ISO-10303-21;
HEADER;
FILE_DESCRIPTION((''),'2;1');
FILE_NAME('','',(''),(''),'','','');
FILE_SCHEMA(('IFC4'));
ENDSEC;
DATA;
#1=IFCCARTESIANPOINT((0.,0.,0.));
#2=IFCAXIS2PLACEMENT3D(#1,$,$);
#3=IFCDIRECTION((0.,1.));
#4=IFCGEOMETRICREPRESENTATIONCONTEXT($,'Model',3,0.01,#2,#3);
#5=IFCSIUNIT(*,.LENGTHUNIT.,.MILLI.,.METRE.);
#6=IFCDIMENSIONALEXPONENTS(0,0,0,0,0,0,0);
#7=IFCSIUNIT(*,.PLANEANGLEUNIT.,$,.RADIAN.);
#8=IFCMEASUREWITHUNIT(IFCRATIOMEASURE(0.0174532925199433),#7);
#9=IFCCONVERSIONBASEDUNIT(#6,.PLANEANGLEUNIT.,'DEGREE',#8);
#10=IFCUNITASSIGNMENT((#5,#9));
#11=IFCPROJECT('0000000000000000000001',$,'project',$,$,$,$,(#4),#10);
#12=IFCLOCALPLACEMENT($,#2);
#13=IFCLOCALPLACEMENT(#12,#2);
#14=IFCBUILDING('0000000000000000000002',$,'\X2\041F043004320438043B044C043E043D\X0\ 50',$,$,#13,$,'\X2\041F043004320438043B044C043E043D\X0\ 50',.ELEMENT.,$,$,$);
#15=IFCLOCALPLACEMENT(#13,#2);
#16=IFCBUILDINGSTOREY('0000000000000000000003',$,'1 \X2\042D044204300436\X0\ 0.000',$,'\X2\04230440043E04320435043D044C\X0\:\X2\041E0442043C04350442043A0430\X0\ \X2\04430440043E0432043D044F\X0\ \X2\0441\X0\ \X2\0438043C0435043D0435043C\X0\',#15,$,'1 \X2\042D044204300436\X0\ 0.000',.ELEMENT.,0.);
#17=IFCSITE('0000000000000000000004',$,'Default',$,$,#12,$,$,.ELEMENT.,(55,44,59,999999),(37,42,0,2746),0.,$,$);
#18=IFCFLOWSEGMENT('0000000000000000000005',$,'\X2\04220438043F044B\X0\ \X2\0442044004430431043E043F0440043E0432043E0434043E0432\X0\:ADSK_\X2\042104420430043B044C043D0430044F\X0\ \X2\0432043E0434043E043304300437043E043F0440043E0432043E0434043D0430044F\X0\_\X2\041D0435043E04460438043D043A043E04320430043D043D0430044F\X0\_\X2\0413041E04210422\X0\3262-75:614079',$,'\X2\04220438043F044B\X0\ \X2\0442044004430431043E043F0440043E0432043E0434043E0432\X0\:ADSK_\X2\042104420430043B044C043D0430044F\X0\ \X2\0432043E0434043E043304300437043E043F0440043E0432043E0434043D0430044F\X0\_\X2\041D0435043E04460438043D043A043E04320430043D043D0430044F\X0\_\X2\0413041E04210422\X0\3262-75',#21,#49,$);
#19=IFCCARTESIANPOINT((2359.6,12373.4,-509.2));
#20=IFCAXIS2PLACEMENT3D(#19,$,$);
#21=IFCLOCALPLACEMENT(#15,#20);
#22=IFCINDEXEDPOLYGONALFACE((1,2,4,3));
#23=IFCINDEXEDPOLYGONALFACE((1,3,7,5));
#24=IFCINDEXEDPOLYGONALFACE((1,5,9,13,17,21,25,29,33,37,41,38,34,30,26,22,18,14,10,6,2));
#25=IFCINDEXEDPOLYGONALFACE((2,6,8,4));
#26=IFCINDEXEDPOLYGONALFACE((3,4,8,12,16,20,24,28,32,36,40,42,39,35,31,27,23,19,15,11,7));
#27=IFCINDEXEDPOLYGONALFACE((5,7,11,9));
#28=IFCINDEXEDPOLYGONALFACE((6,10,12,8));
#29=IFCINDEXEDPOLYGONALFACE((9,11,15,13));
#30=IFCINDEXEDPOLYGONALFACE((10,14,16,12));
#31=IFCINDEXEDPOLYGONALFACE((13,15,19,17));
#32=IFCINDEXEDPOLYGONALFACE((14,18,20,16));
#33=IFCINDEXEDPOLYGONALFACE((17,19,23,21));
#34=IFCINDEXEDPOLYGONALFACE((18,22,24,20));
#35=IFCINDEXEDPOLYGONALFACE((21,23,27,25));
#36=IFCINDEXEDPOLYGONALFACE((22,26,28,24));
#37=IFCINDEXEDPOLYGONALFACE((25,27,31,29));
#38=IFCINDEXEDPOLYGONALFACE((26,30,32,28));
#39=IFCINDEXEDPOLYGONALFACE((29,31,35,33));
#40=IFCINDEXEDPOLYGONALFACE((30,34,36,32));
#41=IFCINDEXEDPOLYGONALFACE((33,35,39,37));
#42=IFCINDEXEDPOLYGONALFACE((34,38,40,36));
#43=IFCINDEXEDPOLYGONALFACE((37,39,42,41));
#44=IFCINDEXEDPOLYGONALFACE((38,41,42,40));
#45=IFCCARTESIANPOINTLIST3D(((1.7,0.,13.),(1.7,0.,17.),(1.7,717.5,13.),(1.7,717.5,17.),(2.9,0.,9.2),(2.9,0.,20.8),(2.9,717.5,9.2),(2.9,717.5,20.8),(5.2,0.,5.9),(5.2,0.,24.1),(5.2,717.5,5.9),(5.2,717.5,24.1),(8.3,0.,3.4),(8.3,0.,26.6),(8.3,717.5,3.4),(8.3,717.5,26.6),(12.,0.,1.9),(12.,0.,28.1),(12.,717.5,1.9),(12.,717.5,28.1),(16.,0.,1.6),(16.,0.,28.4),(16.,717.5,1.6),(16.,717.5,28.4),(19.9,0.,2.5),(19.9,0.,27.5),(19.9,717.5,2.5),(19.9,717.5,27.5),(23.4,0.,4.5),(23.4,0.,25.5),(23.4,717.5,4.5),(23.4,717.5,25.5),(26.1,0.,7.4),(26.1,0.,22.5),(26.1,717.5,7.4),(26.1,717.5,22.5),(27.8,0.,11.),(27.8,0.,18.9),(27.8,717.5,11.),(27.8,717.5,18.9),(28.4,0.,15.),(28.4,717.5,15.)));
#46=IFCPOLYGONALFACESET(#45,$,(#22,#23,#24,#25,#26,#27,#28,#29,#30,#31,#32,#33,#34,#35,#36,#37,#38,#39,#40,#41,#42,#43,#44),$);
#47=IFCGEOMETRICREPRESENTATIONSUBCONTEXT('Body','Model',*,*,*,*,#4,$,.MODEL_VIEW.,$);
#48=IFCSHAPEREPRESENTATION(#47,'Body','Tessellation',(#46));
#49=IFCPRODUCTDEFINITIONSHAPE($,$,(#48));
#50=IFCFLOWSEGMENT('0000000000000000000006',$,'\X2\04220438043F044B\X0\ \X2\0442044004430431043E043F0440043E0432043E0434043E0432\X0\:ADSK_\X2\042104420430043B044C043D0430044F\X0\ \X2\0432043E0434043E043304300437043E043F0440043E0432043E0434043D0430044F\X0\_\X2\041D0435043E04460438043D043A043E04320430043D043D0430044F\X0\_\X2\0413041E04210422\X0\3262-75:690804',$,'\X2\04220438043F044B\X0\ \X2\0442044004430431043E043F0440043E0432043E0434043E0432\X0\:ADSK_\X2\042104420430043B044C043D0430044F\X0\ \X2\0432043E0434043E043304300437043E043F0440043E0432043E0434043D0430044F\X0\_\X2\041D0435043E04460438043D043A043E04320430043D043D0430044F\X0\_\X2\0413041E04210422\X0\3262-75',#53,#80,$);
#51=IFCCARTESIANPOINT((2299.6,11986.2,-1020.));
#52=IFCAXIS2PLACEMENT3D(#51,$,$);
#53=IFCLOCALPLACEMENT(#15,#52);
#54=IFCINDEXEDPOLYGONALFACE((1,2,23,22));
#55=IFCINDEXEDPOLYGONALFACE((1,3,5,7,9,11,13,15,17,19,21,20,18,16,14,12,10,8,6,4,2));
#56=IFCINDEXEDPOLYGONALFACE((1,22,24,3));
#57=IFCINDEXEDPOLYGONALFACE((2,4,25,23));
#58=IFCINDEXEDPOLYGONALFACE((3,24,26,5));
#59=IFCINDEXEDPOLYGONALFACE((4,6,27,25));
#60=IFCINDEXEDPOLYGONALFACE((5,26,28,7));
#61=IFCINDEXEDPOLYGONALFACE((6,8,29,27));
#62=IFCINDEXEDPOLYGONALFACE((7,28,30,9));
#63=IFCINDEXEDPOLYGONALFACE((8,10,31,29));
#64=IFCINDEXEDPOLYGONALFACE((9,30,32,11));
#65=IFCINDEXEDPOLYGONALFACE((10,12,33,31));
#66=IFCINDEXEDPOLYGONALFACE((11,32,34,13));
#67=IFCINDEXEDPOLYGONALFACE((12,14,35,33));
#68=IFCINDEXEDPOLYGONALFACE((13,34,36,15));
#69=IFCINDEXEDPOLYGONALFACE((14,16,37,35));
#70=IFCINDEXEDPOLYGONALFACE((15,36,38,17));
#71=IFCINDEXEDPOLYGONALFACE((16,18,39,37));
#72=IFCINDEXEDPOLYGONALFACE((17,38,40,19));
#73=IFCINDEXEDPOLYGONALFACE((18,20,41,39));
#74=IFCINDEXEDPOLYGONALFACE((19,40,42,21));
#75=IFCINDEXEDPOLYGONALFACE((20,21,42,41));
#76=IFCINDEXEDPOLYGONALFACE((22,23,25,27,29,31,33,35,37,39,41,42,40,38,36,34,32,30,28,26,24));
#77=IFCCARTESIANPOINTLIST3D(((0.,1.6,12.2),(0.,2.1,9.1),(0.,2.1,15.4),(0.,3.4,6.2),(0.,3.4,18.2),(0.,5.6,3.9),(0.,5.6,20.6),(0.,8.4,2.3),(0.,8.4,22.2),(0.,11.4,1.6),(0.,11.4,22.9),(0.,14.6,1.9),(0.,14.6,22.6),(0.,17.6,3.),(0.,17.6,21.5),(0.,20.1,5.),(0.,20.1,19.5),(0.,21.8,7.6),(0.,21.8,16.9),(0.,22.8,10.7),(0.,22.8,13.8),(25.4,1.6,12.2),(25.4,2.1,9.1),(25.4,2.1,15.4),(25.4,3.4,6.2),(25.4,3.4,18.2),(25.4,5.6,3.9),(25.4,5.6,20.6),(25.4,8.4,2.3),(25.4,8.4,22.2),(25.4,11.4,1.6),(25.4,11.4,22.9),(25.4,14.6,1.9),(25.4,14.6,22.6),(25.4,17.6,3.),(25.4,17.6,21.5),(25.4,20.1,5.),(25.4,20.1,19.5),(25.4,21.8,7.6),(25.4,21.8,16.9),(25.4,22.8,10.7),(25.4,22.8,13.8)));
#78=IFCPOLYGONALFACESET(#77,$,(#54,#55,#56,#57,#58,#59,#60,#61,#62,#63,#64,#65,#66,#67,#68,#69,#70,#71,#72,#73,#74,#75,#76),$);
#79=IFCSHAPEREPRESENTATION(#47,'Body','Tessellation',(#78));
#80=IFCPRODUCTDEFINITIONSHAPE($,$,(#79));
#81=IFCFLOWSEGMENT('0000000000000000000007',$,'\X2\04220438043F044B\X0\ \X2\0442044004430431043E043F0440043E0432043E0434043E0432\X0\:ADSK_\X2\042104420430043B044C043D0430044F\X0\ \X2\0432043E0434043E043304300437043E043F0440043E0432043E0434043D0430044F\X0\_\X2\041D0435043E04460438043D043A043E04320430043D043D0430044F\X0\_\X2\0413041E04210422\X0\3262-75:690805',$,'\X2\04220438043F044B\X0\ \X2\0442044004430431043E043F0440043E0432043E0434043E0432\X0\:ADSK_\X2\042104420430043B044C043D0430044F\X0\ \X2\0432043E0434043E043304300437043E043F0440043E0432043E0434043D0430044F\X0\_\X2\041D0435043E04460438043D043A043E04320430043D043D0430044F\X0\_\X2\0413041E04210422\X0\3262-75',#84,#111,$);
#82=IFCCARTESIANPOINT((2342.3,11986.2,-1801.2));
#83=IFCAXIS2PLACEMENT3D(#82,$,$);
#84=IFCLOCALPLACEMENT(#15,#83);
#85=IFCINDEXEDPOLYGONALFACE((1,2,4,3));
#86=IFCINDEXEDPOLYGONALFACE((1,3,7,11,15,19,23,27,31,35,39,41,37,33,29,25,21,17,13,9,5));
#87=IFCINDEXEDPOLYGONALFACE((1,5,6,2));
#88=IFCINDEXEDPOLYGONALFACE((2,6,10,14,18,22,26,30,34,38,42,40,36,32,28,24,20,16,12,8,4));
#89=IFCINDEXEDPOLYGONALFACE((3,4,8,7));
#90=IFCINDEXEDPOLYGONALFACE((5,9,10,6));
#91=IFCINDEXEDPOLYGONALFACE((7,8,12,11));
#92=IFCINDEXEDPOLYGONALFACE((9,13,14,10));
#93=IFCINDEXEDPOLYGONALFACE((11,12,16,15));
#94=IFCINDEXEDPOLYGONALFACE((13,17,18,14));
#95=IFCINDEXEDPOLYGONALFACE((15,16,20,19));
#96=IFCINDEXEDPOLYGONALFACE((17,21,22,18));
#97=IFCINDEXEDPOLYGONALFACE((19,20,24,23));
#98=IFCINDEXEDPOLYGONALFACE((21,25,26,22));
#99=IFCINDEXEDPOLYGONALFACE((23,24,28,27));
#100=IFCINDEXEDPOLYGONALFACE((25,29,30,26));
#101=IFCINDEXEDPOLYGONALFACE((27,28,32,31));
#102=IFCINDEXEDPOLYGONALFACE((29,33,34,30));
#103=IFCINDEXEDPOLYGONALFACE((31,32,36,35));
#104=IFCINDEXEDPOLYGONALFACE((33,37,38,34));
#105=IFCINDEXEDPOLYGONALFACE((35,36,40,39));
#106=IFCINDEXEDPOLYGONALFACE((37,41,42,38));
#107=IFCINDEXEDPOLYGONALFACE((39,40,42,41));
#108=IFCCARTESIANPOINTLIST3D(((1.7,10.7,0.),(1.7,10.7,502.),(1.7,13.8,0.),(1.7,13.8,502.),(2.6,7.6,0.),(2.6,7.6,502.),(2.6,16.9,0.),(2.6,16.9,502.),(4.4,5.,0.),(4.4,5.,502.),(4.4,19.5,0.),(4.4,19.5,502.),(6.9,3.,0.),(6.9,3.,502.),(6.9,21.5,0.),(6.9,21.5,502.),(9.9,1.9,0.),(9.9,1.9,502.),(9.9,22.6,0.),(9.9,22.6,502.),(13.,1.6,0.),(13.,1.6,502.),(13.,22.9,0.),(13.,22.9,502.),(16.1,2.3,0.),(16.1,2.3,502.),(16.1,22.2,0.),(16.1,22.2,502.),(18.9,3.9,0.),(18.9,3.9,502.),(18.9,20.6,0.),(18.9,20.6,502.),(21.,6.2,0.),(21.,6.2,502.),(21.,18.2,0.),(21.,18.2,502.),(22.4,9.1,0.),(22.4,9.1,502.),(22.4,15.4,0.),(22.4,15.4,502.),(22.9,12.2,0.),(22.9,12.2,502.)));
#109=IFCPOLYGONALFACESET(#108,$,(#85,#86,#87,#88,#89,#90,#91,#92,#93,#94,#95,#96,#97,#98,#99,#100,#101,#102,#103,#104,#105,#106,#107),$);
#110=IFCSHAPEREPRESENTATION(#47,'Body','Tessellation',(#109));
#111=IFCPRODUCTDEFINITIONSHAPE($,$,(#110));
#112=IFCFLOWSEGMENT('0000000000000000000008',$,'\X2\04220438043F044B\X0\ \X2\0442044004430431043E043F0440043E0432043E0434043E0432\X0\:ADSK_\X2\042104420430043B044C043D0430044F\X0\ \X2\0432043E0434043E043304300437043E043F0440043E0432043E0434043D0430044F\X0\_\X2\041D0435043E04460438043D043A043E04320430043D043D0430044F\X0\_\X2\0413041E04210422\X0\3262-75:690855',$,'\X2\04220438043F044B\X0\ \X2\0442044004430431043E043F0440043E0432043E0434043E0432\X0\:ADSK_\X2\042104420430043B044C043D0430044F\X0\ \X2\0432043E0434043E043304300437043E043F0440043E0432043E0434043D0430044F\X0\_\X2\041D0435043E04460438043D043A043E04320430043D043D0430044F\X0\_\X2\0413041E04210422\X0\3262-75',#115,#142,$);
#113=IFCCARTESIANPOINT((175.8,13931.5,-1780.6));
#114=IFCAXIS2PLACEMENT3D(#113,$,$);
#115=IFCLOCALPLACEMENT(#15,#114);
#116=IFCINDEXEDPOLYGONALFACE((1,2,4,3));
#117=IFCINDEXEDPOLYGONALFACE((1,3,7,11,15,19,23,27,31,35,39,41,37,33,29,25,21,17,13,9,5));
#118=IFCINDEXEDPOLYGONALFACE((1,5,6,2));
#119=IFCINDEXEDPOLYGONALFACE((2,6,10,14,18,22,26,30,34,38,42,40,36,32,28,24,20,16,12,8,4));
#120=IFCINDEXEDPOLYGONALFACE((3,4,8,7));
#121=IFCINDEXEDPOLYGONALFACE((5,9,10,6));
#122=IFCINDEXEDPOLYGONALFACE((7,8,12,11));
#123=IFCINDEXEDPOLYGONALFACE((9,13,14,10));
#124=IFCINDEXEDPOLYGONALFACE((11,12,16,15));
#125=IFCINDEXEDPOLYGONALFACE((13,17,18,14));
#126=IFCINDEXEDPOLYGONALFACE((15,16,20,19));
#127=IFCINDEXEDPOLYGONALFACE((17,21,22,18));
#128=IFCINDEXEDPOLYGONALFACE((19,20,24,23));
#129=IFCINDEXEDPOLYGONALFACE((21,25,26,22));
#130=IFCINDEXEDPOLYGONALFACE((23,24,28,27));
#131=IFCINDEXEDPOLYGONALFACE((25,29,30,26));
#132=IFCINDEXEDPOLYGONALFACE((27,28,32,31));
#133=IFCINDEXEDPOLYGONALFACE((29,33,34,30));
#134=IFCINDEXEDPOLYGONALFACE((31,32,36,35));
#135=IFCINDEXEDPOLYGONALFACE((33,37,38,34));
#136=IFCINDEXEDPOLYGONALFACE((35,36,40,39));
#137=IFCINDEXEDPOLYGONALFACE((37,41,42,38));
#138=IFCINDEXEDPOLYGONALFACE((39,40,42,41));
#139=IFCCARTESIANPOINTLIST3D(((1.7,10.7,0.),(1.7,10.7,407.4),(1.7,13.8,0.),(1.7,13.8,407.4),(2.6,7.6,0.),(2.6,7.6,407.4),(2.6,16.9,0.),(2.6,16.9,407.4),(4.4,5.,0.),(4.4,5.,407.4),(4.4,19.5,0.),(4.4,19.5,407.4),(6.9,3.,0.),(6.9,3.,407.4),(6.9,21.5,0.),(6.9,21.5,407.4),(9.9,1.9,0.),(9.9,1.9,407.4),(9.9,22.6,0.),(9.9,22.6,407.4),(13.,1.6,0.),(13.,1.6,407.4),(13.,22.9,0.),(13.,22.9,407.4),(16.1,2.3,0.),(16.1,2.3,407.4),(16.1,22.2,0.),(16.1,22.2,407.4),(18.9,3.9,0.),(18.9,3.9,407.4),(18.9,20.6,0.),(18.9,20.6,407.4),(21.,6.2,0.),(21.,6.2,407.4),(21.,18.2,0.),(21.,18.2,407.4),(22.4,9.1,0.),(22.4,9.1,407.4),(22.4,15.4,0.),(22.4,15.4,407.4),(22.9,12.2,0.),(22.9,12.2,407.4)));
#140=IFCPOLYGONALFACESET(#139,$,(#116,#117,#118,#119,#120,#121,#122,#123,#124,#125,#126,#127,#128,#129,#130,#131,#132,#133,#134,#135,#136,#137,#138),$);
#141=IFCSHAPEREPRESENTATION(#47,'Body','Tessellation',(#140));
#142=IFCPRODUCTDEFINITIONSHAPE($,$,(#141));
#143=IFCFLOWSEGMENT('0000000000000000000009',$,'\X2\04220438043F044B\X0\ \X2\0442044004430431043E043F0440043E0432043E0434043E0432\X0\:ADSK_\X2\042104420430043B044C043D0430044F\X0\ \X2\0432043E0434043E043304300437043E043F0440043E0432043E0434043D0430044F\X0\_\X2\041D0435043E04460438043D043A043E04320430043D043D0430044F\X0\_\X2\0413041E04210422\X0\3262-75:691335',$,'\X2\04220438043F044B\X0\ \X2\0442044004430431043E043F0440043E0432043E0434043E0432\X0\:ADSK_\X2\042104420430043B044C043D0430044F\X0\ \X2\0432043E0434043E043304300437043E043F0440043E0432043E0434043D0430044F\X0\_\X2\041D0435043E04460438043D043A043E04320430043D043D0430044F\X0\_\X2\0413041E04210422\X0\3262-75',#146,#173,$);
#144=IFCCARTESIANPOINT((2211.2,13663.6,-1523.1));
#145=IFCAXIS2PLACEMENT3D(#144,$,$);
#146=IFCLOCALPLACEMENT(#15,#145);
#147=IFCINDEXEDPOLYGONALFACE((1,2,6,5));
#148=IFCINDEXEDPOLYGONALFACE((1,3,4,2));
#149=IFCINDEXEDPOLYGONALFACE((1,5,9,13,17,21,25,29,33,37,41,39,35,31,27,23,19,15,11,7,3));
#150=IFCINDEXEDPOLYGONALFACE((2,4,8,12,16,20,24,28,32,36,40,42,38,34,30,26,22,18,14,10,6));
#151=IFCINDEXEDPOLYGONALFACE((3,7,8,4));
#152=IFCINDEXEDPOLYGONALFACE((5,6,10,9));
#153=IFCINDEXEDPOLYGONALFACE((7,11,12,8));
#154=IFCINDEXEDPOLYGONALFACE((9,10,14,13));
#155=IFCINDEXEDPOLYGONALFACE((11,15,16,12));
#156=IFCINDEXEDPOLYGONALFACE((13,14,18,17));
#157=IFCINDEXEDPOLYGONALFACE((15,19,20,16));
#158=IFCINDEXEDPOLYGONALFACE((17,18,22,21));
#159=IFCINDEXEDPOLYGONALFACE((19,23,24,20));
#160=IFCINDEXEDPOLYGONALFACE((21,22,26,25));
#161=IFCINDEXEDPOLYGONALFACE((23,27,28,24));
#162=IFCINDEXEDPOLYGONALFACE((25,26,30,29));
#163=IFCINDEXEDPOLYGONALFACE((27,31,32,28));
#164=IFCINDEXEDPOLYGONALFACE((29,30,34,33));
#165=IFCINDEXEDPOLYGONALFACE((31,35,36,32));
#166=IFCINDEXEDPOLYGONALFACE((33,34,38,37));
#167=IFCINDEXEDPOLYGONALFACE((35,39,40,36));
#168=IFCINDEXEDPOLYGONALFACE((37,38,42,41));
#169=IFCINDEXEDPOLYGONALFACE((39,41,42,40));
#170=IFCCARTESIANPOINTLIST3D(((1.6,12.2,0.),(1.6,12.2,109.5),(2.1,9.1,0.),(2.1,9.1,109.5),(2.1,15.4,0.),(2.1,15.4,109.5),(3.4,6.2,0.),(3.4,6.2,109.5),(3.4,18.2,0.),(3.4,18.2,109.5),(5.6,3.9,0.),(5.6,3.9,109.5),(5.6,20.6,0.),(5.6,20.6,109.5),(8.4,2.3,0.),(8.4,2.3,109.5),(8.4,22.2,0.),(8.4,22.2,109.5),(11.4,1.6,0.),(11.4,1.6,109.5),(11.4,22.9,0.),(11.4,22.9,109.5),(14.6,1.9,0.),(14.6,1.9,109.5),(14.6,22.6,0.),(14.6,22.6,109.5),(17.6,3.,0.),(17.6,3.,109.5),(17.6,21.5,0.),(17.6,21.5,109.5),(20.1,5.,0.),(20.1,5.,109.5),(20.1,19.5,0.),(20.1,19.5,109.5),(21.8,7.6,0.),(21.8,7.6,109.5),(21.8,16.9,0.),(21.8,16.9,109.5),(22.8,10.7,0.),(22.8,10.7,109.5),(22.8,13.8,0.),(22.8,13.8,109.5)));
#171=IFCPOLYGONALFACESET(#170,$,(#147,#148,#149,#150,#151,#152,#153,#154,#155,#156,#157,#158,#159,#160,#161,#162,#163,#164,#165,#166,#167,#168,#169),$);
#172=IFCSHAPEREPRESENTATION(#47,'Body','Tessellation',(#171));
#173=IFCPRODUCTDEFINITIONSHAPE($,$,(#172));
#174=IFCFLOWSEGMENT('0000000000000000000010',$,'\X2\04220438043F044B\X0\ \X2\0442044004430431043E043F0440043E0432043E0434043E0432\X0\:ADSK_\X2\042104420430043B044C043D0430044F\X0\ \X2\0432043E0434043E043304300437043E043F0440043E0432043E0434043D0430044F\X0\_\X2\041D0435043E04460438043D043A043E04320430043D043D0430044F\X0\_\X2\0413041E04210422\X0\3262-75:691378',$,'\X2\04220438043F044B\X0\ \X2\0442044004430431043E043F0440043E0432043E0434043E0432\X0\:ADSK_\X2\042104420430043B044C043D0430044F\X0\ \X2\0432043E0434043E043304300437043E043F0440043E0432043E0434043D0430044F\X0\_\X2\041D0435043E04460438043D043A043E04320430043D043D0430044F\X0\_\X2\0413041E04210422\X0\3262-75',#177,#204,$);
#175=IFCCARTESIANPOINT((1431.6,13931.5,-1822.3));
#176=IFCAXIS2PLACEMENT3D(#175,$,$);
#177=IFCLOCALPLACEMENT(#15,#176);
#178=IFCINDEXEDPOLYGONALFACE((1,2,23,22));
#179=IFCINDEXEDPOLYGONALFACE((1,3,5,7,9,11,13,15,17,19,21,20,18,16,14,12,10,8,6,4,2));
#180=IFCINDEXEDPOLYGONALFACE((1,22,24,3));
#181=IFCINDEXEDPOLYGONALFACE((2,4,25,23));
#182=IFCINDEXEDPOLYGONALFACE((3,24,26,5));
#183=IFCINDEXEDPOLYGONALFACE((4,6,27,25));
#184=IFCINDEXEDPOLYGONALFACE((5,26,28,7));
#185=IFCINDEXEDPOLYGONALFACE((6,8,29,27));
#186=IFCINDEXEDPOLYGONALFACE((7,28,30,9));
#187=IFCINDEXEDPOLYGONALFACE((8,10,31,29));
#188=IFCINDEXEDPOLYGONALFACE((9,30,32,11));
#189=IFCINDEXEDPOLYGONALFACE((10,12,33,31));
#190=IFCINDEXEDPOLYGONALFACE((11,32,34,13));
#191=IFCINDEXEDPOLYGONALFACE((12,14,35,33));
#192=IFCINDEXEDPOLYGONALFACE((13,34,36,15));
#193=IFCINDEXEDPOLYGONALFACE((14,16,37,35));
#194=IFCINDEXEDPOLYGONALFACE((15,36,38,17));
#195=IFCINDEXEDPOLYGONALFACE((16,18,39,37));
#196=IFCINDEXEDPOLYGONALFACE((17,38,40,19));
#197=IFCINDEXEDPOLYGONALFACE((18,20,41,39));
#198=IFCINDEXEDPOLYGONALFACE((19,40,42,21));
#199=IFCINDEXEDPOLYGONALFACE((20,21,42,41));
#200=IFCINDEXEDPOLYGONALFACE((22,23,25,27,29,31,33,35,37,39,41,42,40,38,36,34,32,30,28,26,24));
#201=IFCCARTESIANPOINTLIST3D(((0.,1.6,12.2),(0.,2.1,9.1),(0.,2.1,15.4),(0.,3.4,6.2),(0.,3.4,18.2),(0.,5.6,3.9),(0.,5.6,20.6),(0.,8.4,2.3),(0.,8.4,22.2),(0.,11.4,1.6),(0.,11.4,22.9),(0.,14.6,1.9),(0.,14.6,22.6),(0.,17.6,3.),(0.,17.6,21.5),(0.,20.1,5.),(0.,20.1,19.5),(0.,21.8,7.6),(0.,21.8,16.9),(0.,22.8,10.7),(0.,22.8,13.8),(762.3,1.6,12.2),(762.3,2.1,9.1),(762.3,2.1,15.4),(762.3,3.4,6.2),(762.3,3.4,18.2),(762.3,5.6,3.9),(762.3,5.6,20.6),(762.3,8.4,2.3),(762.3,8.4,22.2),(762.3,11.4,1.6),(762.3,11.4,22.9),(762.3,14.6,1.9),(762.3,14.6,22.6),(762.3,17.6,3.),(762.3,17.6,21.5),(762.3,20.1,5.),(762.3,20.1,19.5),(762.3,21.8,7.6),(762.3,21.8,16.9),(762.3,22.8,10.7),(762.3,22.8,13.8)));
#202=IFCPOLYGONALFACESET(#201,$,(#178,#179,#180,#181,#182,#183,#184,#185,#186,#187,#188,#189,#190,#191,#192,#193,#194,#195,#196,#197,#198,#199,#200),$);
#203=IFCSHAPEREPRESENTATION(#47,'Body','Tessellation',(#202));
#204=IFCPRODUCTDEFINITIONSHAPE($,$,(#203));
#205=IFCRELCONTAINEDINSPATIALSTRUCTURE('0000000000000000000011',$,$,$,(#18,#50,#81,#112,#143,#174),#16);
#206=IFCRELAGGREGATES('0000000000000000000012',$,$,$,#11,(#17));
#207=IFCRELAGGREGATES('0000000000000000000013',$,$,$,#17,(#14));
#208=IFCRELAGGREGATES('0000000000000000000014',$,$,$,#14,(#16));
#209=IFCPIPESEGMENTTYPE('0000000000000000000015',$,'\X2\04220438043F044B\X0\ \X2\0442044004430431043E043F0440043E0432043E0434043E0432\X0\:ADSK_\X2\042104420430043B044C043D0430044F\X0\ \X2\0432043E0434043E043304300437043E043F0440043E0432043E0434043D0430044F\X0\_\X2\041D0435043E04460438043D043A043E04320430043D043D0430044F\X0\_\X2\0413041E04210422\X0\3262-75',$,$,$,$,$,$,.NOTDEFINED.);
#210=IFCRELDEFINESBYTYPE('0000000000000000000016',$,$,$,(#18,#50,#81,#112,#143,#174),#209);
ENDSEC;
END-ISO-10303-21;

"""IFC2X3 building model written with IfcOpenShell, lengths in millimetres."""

from ifc_helpers import new_model, entity, si_unit, converted_unit, direction, frame, frame_2d, origin, origin_2d_with_axis, place, context, subcontext, project, spatial, circle, extrude, type_object, element, save


model = new_model("IFC2X3")

# Units and contexts
model_context = context("Model", 3, precision=0.01, world=origin(), true_north=direction((0.0, 1.0)))
body_context = subcontext(model_context, "Body", "Model", "MODEL_VIEW")
ifc_project = project(units=[si_unit("LENGTHUNIT", "METRE", prefix="MILLI"), converted_unit("PLANEANGLEUNIT", "DEGREE", entity("IfcRatioMeasure", 0.0174532925199433), si_unit("PLANEANGLEUNIT", "RADIAN"), dimensions=[0, 0, 0, 0, 0, 0, 0])], contexts=[model_context])

# Site, building, storey
site_placement = place(None, origin())
site = spatial("IfcSite", under=ifc_project, at=site_placement, Name="Default", CompositionType="ELEMENT", RefLatitude=(55, 44, 59, 999999), RefLongitude=(37, 42, 0, 2746), RefElevation=0.0)
building_placement = place(site_placement, origin())
building = spatial("IfcBuilding", under=site, at=building_placement, Name="Павильон 50", LongName="Павильон 50", CompositionType="ELEMENT")
storey_placement = place(building_placement, origin())
storey = spatial("IfcBuildingStorey", under=building, at=storey_placement, Name="1 Этаж 0.000", ObjectType="Уровень:Отметка уровня с именем", LongName="1 Этаж 0.000", CompositionType="ELEMENT", Elevation=0.0)

# Flow segments
pipe_segment_type = type_object("IfcPipeSegmentType", Name="Типы трубопроводов:ADSK_Стальная водогазопроводная_Неоцинкованная_ГОСТ3262-75", PredefinedType="NOTDEFINED")
flow_segment_1_placement = place(storey_placement, frame((2359.6, 12373.4, -509.2)))
element("IfcFlowSegment", 1, at=flow_segment_1_placement, inside=storey, type_object=pipe_segment_type, Name="Типы трубопроводов:ADSK_Стальная водогазопроводная_Неоцинкованная_ГОСТ3262-75:614079", ObjectType="Типы трубопроводов:ADSK_Стальная водогазопроводная_Неоцинкованная_ГОСТ3262-75", context=body_context, shape_type="SweptSolid", body=[
    extrude(circle(Radius=13.4, at=frame_2d((0.0, 0.0), x_axis=(1.0, 0.0))), frame((15.0, 0.0, 15.0), z_axis=(0.0, 1.0, 0.0), x_axis=(1.0, 0.0, 0.0)), (0.0, 0.0, 1.0), 717.5),
])
flow_segment_2_placement = place(storey_placement, frame((2299.6, 11986.2, -1020.0)))
element("IfcFlowSegment", 2, at=flow_segment_2_placement, inside=storey, type_object=pipe_segment_type, Name="Типы трубопроводов:ADSK_Стальная водогазопроводная_Неоцинкованная_ГОСТ3262-75:690804", ObjectType="Типы трубопроводов:ADSK_Стальная водогазопроводная_Неоцинкованная_ГОСТ3262-75", context=body_context, shape_type="SweptSolid", body=[
    extrude(circle(Radius=10.7, at=origin_2d_with_axis()), frame((0.0, 12.2, 12.2), z_axis=(1.0, 0.0, 0.0), x_axis=(0.0, -1.0, 0.0)), (0.0, 0.0, 1.0), 25.4),
])
flow_segment_3_placement = place(storey_placement, frame((2342.3, 11986.2, -1801.2)))
element("IfcFlowSegment", 3, at=flow_segment_3_placement, inside=storey, type_object=pipe_segment_type, Name="Типы трубопроводов:ADSK_Стальная водогазопроводная_Неоцинкованная_ГОСТ3262-75:690805", ObjectType="Типы трубопроводов:ADSK_Стальная водогазопроводная_Неоцинкованная_ГОСТ3262-75", context=body_context, shape_type="SweptSolid", body=[
    extrude(circle(Radius=10.7, at=frame_2d((0.0, 0.0), x_axis=(1.0, 0.0))), frame((12.2, 12.2, 0.0)), (0.0, 0.0, 1.0), 502.0),
])
flow_segment_4_placement = place(storey_placement, frame((175.8, 13931.5, -1780.6)))
element("IfcFlowSegment", 4, at=flow_segment_4_placement, inside=storey, type_object=pipe_segment_type, Name="Типы трубопроводов:ADSK_Стальная водогазопроводная_Неоцинкованная_ГОСТ3262-75:690855", ObjectType="Типы трубопроводов:ADSK_Стальная водогазопроводная_Неоцинкованная_ГОСТ3262-75", context=body_context, shape_type="SweptSolid", body=[
    extrude(circle(Radius=10.7, at=origin_2d_with_axis()), frame((12.2, 12.2, 0.0)), (0.0, 0.0, 1.0), 407.4),
])
flow_segment_5_placement = place(storey_placement, frame((2211.2, 13663.6, -1523.1)))
element("IfcFlowSegment", 5, at=flow_segment_5_placement, inside=storey, type_object=pipe_segment_type, Name="Типы трубопроводов:ADSK_Стальная водогазопроводная_Неоцинкованная_ГОСТ3262-75:691335", ObjectType="Типы трубопроводов:ADSK_Стальная водогазопроводная_Неоцинкованная_ГОСТ3262-75", context=body_context, shape_type="SweptSolid", body=[
    extrude(circle(Radius=10.7, at=origin_2d_with_axis()), frame((12.2, 12.2, 0.0), z_axis=(0.0, 0.0, 1.0), x_axis=(-1.0, 0.0, 0.0)), (0.0, 0.0, 1.0), 109.5),
])
flow_segment_6_placement = place(storey_placement, frame((1431.6, 13931.5, -1822.3)))
element("IfcFlowSegment", 6, at=flow_segment_6_placement, inside=storey, type_object=pipe_segment_type, Name="Типы трубопроводов:ADSK_Стальная водогазопроводная_Неоцинкованная_ГОСТ3262-75:691378", ObjectType="Типы трубопроводов:ADSK_Стальная водогазопроводная_Неоцинкованная_ГОСТ3262-75", context=body_context, shape_type="SweptSolid", body=[
    extrude(circle(Radius=10.7, at=frame_2d((0.0, 0.0), x_axis=(1.0, 0.0))), frame((0.0, 12.2, 12.2), z_axis=(1.0, 0.0, 0.0), x_axis=(0.0, -1.0, 0.0)), (0.0, 0.0, 1.0), 762.3),
])

save(model, "model.ifc")
